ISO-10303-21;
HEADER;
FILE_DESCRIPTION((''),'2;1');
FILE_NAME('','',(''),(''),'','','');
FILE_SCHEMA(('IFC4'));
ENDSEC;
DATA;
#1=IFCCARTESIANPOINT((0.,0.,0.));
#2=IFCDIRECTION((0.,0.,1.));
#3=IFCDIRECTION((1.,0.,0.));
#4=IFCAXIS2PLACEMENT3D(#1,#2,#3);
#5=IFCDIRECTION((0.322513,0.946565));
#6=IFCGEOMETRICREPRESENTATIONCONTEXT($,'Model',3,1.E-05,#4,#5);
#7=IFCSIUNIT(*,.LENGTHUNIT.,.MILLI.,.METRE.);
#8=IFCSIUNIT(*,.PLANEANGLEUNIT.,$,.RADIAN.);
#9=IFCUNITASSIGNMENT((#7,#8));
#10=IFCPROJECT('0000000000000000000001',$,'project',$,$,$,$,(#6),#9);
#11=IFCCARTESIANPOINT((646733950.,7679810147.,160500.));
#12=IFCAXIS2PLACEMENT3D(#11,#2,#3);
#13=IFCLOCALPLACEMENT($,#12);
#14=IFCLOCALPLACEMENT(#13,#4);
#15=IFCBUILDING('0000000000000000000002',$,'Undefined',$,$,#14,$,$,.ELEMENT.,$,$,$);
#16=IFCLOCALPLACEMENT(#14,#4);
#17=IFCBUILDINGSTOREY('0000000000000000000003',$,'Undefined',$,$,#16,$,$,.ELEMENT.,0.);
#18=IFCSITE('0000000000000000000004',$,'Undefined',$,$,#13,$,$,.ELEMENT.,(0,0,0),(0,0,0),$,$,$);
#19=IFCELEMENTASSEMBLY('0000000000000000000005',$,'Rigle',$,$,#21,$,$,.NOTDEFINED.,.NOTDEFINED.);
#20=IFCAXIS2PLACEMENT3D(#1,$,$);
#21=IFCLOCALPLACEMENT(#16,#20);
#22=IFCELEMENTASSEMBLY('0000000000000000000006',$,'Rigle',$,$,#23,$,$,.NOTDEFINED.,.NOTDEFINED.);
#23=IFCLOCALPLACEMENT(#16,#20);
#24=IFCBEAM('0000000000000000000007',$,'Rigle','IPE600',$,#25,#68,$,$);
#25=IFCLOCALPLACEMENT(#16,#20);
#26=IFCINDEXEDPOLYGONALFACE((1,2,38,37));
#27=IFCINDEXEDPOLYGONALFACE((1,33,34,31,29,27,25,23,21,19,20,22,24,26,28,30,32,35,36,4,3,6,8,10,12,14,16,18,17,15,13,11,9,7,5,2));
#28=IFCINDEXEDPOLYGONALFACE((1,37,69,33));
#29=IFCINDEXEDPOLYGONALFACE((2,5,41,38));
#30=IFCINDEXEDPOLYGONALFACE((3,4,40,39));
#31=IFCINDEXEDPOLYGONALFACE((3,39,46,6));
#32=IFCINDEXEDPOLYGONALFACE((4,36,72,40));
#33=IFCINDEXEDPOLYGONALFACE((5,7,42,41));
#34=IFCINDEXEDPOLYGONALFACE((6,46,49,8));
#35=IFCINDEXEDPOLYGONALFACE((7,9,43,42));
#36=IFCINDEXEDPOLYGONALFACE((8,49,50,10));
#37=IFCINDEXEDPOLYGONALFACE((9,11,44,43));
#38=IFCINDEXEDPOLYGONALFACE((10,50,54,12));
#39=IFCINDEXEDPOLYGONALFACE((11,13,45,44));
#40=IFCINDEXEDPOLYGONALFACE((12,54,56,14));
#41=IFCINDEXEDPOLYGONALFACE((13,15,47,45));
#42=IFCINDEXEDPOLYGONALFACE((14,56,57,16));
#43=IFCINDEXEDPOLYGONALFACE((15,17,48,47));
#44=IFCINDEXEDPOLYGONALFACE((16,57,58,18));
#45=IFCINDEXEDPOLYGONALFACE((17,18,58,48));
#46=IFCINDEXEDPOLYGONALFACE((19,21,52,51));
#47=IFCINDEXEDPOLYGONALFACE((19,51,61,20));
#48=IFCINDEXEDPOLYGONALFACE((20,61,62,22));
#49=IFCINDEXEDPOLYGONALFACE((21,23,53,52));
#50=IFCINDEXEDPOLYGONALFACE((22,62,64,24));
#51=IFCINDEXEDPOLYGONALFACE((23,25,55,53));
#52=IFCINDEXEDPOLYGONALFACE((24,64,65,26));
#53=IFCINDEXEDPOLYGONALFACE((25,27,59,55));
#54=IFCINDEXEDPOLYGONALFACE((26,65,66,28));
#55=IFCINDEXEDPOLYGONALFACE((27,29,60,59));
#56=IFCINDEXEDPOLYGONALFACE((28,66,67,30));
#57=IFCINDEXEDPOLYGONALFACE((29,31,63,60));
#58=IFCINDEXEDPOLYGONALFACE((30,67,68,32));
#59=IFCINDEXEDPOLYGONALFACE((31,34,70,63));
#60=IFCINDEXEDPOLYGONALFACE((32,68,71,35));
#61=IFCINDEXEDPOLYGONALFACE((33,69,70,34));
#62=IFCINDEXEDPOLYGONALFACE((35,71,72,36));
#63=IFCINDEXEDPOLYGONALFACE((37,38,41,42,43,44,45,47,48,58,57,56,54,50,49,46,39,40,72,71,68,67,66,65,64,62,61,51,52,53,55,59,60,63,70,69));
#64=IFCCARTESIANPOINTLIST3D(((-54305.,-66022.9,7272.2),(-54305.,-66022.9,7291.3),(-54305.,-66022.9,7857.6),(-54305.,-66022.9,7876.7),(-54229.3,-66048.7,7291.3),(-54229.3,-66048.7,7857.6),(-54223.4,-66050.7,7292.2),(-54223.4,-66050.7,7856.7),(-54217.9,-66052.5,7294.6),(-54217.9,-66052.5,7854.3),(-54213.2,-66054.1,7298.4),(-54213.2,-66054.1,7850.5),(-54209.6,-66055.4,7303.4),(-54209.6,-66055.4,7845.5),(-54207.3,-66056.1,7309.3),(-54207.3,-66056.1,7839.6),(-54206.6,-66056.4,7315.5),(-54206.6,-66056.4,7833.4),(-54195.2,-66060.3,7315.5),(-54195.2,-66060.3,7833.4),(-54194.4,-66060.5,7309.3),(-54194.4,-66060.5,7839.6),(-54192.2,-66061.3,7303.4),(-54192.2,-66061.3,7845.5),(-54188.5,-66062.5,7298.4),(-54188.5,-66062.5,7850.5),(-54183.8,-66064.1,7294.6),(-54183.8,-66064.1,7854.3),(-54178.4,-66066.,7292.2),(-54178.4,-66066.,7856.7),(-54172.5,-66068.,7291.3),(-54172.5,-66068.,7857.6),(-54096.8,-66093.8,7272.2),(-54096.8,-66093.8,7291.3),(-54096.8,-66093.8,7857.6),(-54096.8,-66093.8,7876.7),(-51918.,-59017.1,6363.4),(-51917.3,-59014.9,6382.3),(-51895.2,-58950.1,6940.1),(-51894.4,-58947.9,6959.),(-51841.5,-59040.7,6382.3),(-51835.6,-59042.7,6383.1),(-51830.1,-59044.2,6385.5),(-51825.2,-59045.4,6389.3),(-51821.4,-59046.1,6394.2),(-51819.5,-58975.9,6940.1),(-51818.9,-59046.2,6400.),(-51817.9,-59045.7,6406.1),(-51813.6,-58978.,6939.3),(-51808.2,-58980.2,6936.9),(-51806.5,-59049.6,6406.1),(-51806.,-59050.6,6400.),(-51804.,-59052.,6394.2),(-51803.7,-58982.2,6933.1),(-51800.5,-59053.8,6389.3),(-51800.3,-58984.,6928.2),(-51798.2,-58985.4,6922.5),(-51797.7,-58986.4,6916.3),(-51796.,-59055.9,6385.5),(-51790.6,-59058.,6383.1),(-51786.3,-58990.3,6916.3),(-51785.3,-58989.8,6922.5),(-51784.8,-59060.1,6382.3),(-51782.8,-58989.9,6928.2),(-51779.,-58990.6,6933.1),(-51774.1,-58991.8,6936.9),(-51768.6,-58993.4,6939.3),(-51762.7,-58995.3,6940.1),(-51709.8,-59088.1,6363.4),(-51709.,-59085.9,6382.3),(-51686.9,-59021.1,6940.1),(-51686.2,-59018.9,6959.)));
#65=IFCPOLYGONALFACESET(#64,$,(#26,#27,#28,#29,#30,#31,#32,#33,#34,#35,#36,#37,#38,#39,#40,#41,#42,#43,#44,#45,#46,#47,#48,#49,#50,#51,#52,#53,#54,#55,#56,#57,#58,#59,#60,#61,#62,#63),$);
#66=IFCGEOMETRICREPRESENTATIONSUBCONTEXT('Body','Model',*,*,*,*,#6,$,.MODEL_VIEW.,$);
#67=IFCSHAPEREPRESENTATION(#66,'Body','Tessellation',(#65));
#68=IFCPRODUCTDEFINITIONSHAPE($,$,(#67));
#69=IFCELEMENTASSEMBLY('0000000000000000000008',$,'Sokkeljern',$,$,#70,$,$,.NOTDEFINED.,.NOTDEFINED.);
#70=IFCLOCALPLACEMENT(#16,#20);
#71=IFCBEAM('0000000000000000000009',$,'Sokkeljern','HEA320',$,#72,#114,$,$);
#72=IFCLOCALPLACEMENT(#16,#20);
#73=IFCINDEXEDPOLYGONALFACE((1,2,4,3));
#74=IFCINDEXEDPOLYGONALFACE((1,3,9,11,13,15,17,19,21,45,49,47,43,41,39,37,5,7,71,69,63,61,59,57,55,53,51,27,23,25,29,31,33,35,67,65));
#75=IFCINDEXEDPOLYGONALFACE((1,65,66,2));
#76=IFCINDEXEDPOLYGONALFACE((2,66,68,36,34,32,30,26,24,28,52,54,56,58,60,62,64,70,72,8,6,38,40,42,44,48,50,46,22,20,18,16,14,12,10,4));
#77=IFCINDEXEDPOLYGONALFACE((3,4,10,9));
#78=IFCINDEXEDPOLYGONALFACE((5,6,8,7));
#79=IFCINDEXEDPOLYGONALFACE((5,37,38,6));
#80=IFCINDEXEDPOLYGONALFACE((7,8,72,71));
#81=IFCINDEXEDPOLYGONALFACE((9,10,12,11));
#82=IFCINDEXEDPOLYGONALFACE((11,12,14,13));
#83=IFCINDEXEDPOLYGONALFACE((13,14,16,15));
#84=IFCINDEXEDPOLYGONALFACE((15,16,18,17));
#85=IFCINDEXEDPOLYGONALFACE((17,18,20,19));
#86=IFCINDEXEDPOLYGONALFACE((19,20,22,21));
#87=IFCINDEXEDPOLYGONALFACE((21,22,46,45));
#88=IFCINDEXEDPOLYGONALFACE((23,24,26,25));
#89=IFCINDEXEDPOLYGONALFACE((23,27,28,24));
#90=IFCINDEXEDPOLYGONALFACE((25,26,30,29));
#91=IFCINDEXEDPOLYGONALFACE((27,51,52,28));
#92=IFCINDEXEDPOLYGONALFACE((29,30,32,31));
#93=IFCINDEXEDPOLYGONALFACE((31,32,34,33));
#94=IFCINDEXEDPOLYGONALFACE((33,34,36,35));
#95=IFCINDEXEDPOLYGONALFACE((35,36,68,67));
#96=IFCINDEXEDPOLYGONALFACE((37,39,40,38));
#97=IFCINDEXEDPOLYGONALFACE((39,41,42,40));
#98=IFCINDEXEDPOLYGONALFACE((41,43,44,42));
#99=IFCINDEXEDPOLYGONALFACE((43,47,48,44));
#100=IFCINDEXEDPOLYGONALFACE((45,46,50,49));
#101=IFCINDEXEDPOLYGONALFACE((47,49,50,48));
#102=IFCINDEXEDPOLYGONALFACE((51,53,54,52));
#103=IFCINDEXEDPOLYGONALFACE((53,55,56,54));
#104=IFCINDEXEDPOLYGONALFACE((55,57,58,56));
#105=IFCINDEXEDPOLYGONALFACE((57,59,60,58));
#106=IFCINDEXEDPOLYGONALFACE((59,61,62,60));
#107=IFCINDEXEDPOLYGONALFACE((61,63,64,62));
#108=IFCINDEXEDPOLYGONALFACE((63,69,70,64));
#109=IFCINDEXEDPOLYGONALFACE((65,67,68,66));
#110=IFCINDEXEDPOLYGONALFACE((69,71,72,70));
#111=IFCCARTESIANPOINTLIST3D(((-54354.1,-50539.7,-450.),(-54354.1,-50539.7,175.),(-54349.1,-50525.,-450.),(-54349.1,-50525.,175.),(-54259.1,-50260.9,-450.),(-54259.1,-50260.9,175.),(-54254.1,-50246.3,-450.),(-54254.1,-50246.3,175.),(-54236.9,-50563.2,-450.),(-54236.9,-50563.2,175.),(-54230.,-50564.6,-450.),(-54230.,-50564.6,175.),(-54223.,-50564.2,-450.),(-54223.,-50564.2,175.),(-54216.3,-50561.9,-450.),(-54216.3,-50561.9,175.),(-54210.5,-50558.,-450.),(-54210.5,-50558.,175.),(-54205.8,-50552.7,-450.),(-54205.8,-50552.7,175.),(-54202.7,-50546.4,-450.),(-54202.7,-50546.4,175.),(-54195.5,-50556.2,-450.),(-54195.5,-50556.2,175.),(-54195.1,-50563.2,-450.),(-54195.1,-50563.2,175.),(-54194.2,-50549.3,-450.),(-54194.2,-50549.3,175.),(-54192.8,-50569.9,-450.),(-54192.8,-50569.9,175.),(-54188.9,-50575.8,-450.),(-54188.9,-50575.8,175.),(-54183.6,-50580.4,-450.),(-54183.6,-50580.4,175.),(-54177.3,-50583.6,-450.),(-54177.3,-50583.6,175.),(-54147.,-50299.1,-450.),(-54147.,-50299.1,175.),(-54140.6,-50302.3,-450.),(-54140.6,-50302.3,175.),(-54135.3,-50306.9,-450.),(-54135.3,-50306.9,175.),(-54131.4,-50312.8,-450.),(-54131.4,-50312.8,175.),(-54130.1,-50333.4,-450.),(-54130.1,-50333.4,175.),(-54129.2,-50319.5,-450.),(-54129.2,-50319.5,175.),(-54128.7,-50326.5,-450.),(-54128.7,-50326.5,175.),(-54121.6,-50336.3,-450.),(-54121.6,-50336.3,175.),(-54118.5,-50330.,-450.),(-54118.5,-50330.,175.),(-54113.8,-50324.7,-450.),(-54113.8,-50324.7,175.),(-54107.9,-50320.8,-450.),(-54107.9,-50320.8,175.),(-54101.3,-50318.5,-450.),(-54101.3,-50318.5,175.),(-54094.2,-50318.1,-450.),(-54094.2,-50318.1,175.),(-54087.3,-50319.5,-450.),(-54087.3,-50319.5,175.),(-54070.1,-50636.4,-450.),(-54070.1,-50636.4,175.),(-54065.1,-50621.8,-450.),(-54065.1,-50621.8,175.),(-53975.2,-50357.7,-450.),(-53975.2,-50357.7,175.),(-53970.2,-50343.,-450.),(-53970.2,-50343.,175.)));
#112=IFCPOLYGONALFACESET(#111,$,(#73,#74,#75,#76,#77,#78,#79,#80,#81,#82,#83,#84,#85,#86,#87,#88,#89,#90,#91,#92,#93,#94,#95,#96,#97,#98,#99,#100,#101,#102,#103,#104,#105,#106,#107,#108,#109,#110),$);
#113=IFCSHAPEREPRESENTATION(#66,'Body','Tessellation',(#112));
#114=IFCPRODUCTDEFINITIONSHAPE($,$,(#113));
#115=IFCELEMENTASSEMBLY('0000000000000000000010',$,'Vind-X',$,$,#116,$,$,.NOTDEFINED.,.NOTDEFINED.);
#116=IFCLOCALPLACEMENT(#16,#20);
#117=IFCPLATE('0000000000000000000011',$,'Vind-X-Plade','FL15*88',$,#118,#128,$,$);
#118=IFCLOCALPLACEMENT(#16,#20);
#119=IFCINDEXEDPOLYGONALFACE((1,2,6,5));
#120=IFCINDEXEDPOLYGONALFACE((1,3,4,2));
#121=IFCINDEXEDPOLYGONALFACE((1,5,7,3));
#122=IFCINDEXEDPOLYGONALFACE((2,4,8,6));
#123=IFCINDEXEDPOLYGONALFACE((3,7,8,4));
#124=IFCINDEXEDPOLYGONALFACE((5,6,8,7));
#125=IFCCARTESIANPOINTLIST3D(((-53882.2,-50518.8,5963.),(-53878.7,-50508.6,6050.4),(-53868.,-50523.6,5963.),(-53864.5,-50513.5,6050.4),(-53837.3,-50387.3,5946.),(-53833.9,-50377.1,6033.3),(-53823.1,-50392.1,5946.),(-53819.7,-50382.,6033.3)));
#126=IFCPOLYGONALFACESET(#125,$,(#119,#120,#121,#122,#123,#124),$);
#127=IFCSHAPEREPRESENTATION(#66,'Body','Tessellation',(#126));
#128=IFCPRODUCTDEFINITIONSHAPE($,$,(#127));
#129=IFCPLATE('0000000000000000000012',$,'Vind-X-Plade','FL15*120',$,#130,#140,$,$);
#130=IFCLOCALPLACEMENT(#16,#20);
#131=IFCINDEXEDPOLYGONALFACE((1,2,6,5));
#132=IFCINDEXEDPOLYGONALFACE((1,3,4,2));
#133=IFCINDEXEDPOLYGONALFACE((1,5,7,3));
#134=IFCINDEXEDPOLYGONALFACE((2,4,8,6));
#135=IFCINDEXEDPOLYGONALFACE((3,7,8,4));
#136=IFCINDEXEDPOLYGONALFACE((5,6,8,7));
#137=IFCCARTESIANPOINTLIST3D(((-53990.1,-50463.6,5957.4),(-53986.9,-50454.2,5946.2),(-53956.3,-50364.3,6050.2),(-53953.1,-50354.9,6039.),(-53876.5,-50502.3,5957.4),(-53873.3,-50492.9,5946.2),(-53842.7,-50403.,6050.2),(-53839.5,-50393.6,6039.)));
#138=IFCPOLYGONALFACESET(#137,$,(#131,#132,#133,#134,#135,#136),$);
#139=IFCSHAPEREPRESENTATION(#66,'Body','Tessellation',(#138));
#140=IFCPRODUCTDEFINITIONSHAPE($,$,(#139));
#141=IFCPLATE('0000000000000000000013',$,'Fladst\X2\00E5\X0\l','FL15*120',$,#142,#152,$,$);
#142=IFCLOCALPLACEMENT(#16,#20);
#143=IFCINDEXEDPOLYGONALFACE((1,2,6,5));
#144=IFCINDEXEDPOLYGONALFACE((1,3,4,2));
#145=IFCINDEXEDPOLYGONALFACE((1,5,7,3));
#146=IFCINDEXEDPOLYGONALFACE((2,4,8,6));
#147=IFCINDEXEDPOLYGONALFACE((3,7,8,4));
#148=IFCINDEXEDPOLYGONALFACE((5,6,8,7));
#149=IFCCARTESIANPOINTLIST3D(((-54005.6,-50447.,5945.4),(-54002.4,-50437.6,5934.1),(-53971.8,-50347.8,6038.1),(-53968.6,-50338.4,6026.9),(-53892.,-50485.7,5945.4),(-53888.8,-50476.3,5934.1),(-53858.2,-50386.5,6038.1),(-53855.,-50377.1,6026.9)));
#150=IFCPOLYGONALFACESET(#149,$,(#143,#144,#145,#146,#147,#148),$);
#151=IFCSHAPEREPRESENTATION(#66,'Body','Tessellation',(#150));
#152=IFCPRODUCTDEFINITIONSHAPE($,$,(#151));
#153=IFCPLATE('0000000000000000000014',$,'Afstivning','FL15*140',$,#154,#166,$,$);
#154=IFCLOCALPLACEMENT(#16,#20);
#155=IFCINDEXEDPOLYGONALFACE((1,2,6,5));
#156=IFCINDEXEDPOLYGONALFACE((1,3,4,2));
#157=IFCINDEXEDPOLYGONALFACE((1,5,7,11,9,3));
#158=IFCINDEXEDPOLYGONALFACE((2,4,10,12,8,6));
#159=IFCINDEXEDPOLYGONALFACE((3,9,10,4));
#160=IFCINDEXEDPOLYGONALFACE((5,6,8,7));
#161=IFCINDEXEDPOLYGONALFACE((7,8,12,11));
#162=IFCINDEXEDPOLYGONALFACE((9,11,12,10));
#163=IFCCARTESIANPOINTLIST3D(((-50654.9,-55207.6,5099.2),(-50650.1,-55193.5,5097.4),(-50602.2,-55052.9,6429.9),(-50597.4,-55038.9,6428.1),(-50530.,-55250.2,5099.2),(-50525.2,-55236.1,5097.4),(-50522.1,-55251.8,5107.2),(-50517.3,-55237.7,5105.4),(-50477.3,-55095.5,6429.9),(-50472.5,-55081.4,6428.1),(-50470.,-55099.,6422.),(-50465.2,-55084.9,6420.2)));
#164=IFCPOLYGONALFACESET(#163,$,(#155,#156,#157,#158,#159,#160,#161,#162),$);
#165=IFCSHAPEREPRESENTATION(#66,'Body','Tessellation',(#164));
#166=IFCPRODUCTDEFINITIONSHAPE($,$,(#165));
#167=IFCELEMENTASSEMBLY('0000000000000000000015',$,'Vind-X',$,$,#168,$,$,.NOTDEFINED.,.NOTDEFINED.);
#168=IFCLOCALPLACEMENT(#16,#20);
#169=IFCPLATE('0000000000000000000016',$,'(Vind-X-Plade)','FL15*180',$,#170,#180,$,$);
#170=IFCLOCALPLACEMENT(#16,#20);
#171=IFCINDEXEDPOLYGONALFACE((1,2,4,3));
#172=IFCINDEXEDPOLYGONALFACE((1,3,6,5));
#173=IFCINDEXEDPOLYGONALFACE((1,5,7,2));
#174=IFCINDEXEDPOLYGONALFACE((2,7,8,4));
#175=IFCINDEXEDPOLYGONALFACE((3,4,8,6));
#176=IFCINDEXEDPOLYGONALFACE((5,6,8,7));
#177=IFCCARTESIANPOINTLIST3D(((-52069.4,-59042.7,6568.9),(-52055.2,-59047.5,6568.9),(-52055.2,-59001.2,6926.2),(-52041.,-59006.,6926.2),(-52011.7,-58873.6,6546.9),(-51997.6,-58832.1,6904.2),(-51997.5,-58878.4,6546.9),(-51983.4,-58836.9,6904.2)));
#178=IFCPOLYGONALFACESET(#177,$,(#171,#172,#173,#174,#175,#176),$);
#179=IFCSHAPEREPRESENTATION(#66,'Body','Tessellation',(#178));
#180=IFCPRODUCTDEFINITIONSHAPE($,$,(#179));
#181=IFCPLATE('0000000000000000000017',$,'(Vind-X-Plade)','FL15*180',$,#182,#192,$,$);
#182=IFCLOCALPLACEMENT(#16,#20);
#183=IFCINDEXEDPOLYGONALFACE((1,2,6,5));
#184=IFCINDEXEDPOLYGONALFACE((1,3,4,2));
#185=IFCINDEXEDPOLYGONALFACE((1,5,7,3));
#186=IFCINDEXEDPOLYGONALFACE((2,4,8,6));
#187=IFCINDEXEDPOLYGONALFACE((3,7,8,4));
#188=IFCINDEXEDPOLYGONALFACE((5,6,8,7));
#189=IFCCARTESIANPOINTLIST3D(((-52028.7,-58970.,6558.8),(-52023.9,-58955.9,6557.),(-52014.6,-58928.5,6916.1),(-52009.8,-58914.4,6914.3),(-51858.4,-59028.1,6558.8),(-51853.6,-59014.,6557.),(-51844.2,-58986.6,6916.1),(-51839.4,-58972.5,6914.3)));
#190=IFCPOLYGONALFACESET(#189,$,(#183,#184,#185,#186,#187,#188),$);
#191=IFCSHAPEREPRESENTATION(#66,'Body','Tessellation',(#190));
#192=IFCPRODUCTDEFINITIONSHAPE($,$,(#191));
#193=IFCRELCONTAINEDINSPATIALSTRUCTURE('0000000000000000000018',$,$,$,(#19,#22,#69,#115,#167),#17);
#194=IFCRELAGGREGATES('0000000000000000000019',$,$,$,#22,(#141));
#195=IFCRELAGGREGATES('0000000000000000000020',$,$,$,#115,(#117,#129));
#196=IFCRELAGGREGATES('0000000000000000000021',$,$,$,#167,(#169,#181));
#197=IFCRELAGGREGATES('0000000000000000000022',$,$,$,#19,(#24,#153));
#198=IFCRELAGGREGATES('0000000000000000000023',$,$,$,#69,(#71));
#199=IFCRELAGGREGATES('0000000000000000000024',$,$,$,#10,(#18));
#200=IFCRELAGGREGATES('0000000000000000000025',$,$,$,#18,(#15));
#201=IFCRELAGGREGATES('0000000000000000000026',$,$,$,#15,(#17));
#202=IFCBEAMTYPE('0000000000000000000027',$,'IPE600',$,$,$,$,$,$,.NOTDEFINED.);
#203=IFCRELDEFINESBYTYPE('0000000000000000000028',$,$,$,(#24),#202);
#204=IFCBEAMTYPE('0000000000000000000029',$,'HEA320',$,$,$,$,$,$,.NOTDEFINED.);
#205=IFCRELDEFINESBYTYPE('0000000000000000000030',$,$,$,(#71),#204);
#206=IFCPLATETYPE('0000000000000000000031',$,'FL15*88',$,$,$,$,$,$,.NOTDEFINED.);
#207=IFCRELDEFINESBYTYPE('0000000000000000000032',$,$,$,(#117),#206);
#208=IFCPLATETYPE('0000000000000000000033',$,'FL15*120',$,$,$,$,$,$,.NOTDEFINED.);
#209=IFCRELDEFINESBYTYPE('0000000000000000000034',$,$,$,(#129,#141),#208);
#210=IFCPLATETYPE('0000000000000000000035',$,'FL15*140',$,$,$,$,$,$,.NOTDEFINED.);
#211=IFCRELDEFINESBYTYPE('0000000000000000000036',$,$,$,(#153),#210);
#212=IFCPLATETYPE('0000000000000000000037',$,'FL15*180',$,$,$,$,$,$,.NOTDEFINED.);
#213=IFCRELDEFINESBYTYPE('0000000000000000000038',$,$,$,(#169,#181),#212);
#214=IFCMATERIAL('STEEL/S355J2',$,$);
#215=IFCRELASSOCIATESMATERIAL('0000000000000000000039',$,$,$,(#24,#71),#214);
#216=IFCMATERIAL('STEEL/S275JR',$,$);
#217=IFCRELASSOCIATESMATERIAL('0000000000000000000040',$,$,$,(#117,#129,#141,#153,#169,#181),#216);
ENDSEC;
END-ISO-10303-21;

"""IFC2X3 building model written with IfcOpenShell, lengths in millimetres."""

from ifc_helpers import new_model, si_unit, direction, frame, origin_with_axes, origin_2d_with_axis, place, context, subcontext, project, spatial, polyline, i_section, outline, extrude, clip, halfspace, material, type_object, element, aggregate, save


model = new_model("IFC2X3")

# Units and contexts
model_context = context("Model", 3, precision=1e-05, world=origin_with_axes(), true_north=direction((0.322513, 0.946565)))
body_context = subcontext(model_context, "Body", "Model", "MODEL_VIEW")
ifc_project = project(units=[si_unit("LENGTHUNIT", "METRE", prefix="MILLI"), si_unit("PLANEANGLEUNIT", "RADIAN")], contexts=[model_context])

# Site, building, storey
site_placement = place(None, frame((646733950.0, 7679810147.0, 160500.0), z_axis=(0.0, 0.0, 1.0), x_axis=(1.0, 0.0, 0.0)))
site = spatial("IfcSite", under=ifc_project, at=site_placement, Name="Undefined", CompositionType="ELEMENT", RefLatitude=(0, 0, 0), RefLongitude=(0, 0, 0))
building_placement = place(site_placement, origin_with_axes())
building = spatial("IfcBuilding", under=site, at=building_placement, Name="Undefined", CompositionType="ELEMENT")
storey_placement = place(building_placement, origin_with_axes())
storey = spatial("IfcBuildingStorey", under=building, at=storey_placement, Name="Undefined", CompositionType="ELEMENT", Elevation=0.0)

# Element assemblies
assembly_1_placement = place(storey_placement, origin_with_axes())
assembly_1 = element("IfcElementAssembly", 1, at=assembly_1_placement, inside=storey, Name="Rigle", AssemblyPlace="NOTDEFINED", PredefinedType="NOTDEFINED")
ifc_material_1 = material(Name="STEEL/S355J2")
assembly_2_placement = place(storey_placement, origin_with_axes())
assembly_2 = element("IfcElementAssembly", 2, at=assembly_2_placement, inside=storey, Name="Rigle", AssemblyPlace="NOTDEFINED", PredefinedType="NOTDEFINED")

# Beam
beam_type_1 = type_object("IfcBeamType", Name="IPE600", PredefinedType="NOTDEFINED")
beam_1_placement = place(assembly_1_placement, frame((-51798.1, -59006.3, 6659.7), z_axis=(0.039304, 0.115357, 0.992546), x_axis=(-0.320109, -0.93951, 0.121869)))
beam_1 = element("IfcBeam", 3, at=beam_1_placement, type_object=beam_type_1, material=ifc_material_1, Name="Rigle", Description="IPE600", context=body_context, shape_type="Clipping", body=[
    clip(clip(extrude(i_section(OverallWidth=220.0, OverallDepth=600.0, WebThickness=12.0, FlangeThickness=19.0, FilletRadius=24.0, at=origin_2d_with_axis()), frame((7751.3, 0.0, 0.0), z_axis=(-1.0, 0.0, 0.0), x_axis=(0.0, -1.0, 0.0)), (0.0, 0.0, 1.0), 7983.9), halfspace(frame((7543.3, 0.0, 303.0), z_axis=(0.992546, 0.0, -0.121869), x_axis=(0.0, 1.0, 0.0)), False)), halfspace(frame((12.5, 0.0, 0.0), z_axis=(-1.0, 0.0, 0.0), x_axis=(0.0, 1.0, 0.0)), False)),
])

# Element assembly, beam
assembly_3_placement = place(storey_placement, origin_with_axes())
assembly_3 = element("IfcElementAssembly", 4, at=assembly_3_placement, inside=storey, Name="Sokkeljern", AssemblyPlace="NOTDEFINED", PredefinedType="NOTDEFINED")
beam_type_2 = type_object("IfcBeamType", Name="HEA320", PredefinedType="NOTDEFINED")
beam_2_placement = place(assembly_3_placement, frame((-54162.1, -50441.3, 175.0), z_axis=(-0.322513, -0.946565, 0.0), x_axis=(0.0, 0.0, -1.0)))
beam_2 = element("IfcBeam", 5, at=beam_2_placement, type_object=beam_type_2, material=ifc_material_1, Name="Sokkeljern", Description="HEA320", context=body_context, shape_type="SweptSolid", body=[
    extrude(i_section(OverallWidth=300.0, OverallDepth=310.0, WebThickness=9.0, FlangeThickness=15.5, FilletRadius=27.0, at=origin_2d_with_axis()), frame((625.0, 0.0, 0.0), z_axis=(-1.0, 0.0, 0.0), x_axis=(0.0, -1.0, 0.0)), (0.0, 0.0, 1.0), 625.0),
])

# Element assembly, plates
assembly_4_placement = place(storey_placement, origin_with_axes())
assembly_4 = element("IfcElementAssembly", 6, at=assembly_4_placement, inside=storey, Name="Vind-X", AssemblyPlace="NOTDEFINED", PredefinedType="NOTDEFINED")
ifc_material_2 = material(Name="STEEL/S275JR")
plate_type_1 = type_object("IfcPlateType", Name="FL15*88", PredefinedType="NOTDEFINED")
plate_1_placement = place(assembly_4_placement, frame((-53875.1, -50521.2, 5963.0), z_axis=(0.946565, -0.322513, 0.0), x_axis=(0.320109, 0.93951, -0.121869)))
plate_1 = element("IfcPlate", 7, at=plate_1_placement, type_object=plate_type_1, material=ifc_material_2, Name="Vind-X-Plade", Description="FL15*88", context=body_context, shape_type="SweptSolid", body=[
    extrude(outline(polyline([(0.0, 0.0), (140.0, 0.0), (140.0, 88.0), (0.0, 88.0), (0.0, 0.0)])), frame((0.0, 0.0, -7.5), z_axis=(0.0, 0.0, 1.0), x_axis=(1.0, 0.0, 0.0)), (0.0, 0.0, 1.0), 15.0),
])
plate_type_2 = type_object("IfcPlateType", Name="FL15*120", PredefinedType="NOTDEFINED")
plate_2_placement = place(assembly_4_placement, frame((-53971.6, -50409.3, 5998.2), z_axis=(-0.213703, -0.627213, 0.748956), x_axis=(0.946565, -0.322513, 0.0)))
plate_2 = element("IfcPlate", 8, at=plate_2_placement, type_object=plate_type_2, material=ifc_material_2, Name="Vind-X-Plade", Description="FL15*120", context=body_context, shape_type="SweptSolid", body=[
    extrude(outline(polyline([(0.0, -70.0), (0.0, 70.0), (120.0, 70.0), (120.0, -70.0), (0.0, -70.0)])), frame((0.0, 0.0, -7.5), z_axis=(0.0, 0.0, 1.0), x_axis=(1.0, 0.0, 0.0)), (0.0, 0.0, 1.0), 15.0),
])

# Plates
plate_3_placement = place(assembly_2_placement, frame((-54004.0, -50442.3, 5939.7), z_axis=(0.213703, 0.627213, -0.748956), x_axis=(0.241548, 0.708935, 0.66262)))
plate_3 = element("IfcPlate", 9, at=plate_3_placement, type_object=plate_type_2, material=ifc_material_2, Name="Fladstål", Description="FL15*120", context=body_context, shape_type="SweptSolid", body=[
    extrude(outline(polyline([(0.0, 0.0), (140.0, 0.0), (140.0, 120.0), (0.0, 120.0), (0.0, 0.0)])), frame((0.0, 0.0, -7.5), z_axis=(0.0, 0.0, 1.0), x_axis=(1.0, 0.0, 0.0)), (0.0, 0.0, 1.0), 15.0),
])
plate_type_3 = type_object("IfcPlateType", Name="FL15*140", PredefinedType="NOTDEFINED")
plate_4_placement = place(assembly_1_placement, frame((-50520.0, -55245.7, 5098.3), z_axis=(0.320109, 0.93951, -0.121869), x_axis=(-0.946565, 0.322513, 0.0)))
plate_4 = element("IfcPlate", 10, at=plate_4_placement, type_object=plate_type_3, material=ifc_material_2, Name="Afstivning", Description="FL15*140", context=body_context, shape_type="SweptSolid", body=[
    extrude(outline(polyline([(0.0, 8.0), (8.0, 0.0), (140.0, 0.0), (140.0, 1340.7), (8.0, 1340.7), (0.0, 1332.7), (0.0, 8.0)])), frame((0.0, 0.0, -7.5), z_axis=(0.0, 0.0, 1.0), x_axis=(1.0, 0.0, 0.0)), (0.0, 0.0, 1.0), 15.0),
])

# Element assembly, plates
assembly_5_placement = place(storey_placement, origin_with_axes())
assembly_5 = element("IfcElementAssembly", 11, at=assembly_5_placement, inside=storey, Name="Vind-X", AssemblyPlace="NOTDEFINED", PredefinedType="NOTDEFINED")
plate_type_4 = type_object("IfcPlateType", Name="FL15*180", PredefinedType="NOTDEFINED")
plate_5_placement = place(assembly_5_placement, frame((-51990.5, -58834.5, 6904.2), z_axis=(0.946565, -0.322513, 0.0), x_axis=(-0.320109, -0.93951, 0.121869)))
plate_5 = element("IfcPlate", 12, at=plate_5_placement, type_object=plate_type_4, material=ifc_material_2, Name="(Vind-X-Plade)", Description="FL15*180", context=body_context, shape_type="SweptSolid", body=[
    extrude(outline(polyline([(0.0, 0.0), (180.0, 0.0), (180.0, 360.0), (0.0, 360.0), (0.0, 0.0)])), frame((0.0, 0.0, -7.5), z_axis=(0.0, 0.0, 1.0), x_axis=(1.0, 0.0, 0.0)), (0.0, 0.0, 1.0), 15.0),
])
plate_6_placement = place(assembly_5_placement, frame((-51856.0, -59021.0, 6557.9), z_axis=(-0.320109, -0.93951, 0.121869), x_axis=(0.039304, 0.115357, 0.992546)))
plate_6 = element("IfcPlate", 13, at=plate_6_placement, type_object=plate_type_4, material=ifc_material_2, Name="(Vind-X-Plade)", Description="FL15*180", context=body_context, shape_type="SweptSolid", body=[
    extrude(outline(polyline([(0.0, 0.0), (360.0, 0.0), (360.0, 180.0), (0.0, 180.0), (0.0, 0.0)])), frame((0.0, 0.0, -7.5), z_axis=(0.0, 0.0, 1.0), x_axis=(1.0, 0.0, 0.0)), (0.0, 0.0, 1.0), 15.0),
])

aggregate(assembly_2, [plate_3])

aggregate(assembly_4, [plate_1, plate_2])
aggregate(assembly_5, [plate_5, plate_6])
aggregate(assembly_1, [beam_1, plate_4])
aggregate(assembly_3, [beam_2])

save(model, "model.ifc")
